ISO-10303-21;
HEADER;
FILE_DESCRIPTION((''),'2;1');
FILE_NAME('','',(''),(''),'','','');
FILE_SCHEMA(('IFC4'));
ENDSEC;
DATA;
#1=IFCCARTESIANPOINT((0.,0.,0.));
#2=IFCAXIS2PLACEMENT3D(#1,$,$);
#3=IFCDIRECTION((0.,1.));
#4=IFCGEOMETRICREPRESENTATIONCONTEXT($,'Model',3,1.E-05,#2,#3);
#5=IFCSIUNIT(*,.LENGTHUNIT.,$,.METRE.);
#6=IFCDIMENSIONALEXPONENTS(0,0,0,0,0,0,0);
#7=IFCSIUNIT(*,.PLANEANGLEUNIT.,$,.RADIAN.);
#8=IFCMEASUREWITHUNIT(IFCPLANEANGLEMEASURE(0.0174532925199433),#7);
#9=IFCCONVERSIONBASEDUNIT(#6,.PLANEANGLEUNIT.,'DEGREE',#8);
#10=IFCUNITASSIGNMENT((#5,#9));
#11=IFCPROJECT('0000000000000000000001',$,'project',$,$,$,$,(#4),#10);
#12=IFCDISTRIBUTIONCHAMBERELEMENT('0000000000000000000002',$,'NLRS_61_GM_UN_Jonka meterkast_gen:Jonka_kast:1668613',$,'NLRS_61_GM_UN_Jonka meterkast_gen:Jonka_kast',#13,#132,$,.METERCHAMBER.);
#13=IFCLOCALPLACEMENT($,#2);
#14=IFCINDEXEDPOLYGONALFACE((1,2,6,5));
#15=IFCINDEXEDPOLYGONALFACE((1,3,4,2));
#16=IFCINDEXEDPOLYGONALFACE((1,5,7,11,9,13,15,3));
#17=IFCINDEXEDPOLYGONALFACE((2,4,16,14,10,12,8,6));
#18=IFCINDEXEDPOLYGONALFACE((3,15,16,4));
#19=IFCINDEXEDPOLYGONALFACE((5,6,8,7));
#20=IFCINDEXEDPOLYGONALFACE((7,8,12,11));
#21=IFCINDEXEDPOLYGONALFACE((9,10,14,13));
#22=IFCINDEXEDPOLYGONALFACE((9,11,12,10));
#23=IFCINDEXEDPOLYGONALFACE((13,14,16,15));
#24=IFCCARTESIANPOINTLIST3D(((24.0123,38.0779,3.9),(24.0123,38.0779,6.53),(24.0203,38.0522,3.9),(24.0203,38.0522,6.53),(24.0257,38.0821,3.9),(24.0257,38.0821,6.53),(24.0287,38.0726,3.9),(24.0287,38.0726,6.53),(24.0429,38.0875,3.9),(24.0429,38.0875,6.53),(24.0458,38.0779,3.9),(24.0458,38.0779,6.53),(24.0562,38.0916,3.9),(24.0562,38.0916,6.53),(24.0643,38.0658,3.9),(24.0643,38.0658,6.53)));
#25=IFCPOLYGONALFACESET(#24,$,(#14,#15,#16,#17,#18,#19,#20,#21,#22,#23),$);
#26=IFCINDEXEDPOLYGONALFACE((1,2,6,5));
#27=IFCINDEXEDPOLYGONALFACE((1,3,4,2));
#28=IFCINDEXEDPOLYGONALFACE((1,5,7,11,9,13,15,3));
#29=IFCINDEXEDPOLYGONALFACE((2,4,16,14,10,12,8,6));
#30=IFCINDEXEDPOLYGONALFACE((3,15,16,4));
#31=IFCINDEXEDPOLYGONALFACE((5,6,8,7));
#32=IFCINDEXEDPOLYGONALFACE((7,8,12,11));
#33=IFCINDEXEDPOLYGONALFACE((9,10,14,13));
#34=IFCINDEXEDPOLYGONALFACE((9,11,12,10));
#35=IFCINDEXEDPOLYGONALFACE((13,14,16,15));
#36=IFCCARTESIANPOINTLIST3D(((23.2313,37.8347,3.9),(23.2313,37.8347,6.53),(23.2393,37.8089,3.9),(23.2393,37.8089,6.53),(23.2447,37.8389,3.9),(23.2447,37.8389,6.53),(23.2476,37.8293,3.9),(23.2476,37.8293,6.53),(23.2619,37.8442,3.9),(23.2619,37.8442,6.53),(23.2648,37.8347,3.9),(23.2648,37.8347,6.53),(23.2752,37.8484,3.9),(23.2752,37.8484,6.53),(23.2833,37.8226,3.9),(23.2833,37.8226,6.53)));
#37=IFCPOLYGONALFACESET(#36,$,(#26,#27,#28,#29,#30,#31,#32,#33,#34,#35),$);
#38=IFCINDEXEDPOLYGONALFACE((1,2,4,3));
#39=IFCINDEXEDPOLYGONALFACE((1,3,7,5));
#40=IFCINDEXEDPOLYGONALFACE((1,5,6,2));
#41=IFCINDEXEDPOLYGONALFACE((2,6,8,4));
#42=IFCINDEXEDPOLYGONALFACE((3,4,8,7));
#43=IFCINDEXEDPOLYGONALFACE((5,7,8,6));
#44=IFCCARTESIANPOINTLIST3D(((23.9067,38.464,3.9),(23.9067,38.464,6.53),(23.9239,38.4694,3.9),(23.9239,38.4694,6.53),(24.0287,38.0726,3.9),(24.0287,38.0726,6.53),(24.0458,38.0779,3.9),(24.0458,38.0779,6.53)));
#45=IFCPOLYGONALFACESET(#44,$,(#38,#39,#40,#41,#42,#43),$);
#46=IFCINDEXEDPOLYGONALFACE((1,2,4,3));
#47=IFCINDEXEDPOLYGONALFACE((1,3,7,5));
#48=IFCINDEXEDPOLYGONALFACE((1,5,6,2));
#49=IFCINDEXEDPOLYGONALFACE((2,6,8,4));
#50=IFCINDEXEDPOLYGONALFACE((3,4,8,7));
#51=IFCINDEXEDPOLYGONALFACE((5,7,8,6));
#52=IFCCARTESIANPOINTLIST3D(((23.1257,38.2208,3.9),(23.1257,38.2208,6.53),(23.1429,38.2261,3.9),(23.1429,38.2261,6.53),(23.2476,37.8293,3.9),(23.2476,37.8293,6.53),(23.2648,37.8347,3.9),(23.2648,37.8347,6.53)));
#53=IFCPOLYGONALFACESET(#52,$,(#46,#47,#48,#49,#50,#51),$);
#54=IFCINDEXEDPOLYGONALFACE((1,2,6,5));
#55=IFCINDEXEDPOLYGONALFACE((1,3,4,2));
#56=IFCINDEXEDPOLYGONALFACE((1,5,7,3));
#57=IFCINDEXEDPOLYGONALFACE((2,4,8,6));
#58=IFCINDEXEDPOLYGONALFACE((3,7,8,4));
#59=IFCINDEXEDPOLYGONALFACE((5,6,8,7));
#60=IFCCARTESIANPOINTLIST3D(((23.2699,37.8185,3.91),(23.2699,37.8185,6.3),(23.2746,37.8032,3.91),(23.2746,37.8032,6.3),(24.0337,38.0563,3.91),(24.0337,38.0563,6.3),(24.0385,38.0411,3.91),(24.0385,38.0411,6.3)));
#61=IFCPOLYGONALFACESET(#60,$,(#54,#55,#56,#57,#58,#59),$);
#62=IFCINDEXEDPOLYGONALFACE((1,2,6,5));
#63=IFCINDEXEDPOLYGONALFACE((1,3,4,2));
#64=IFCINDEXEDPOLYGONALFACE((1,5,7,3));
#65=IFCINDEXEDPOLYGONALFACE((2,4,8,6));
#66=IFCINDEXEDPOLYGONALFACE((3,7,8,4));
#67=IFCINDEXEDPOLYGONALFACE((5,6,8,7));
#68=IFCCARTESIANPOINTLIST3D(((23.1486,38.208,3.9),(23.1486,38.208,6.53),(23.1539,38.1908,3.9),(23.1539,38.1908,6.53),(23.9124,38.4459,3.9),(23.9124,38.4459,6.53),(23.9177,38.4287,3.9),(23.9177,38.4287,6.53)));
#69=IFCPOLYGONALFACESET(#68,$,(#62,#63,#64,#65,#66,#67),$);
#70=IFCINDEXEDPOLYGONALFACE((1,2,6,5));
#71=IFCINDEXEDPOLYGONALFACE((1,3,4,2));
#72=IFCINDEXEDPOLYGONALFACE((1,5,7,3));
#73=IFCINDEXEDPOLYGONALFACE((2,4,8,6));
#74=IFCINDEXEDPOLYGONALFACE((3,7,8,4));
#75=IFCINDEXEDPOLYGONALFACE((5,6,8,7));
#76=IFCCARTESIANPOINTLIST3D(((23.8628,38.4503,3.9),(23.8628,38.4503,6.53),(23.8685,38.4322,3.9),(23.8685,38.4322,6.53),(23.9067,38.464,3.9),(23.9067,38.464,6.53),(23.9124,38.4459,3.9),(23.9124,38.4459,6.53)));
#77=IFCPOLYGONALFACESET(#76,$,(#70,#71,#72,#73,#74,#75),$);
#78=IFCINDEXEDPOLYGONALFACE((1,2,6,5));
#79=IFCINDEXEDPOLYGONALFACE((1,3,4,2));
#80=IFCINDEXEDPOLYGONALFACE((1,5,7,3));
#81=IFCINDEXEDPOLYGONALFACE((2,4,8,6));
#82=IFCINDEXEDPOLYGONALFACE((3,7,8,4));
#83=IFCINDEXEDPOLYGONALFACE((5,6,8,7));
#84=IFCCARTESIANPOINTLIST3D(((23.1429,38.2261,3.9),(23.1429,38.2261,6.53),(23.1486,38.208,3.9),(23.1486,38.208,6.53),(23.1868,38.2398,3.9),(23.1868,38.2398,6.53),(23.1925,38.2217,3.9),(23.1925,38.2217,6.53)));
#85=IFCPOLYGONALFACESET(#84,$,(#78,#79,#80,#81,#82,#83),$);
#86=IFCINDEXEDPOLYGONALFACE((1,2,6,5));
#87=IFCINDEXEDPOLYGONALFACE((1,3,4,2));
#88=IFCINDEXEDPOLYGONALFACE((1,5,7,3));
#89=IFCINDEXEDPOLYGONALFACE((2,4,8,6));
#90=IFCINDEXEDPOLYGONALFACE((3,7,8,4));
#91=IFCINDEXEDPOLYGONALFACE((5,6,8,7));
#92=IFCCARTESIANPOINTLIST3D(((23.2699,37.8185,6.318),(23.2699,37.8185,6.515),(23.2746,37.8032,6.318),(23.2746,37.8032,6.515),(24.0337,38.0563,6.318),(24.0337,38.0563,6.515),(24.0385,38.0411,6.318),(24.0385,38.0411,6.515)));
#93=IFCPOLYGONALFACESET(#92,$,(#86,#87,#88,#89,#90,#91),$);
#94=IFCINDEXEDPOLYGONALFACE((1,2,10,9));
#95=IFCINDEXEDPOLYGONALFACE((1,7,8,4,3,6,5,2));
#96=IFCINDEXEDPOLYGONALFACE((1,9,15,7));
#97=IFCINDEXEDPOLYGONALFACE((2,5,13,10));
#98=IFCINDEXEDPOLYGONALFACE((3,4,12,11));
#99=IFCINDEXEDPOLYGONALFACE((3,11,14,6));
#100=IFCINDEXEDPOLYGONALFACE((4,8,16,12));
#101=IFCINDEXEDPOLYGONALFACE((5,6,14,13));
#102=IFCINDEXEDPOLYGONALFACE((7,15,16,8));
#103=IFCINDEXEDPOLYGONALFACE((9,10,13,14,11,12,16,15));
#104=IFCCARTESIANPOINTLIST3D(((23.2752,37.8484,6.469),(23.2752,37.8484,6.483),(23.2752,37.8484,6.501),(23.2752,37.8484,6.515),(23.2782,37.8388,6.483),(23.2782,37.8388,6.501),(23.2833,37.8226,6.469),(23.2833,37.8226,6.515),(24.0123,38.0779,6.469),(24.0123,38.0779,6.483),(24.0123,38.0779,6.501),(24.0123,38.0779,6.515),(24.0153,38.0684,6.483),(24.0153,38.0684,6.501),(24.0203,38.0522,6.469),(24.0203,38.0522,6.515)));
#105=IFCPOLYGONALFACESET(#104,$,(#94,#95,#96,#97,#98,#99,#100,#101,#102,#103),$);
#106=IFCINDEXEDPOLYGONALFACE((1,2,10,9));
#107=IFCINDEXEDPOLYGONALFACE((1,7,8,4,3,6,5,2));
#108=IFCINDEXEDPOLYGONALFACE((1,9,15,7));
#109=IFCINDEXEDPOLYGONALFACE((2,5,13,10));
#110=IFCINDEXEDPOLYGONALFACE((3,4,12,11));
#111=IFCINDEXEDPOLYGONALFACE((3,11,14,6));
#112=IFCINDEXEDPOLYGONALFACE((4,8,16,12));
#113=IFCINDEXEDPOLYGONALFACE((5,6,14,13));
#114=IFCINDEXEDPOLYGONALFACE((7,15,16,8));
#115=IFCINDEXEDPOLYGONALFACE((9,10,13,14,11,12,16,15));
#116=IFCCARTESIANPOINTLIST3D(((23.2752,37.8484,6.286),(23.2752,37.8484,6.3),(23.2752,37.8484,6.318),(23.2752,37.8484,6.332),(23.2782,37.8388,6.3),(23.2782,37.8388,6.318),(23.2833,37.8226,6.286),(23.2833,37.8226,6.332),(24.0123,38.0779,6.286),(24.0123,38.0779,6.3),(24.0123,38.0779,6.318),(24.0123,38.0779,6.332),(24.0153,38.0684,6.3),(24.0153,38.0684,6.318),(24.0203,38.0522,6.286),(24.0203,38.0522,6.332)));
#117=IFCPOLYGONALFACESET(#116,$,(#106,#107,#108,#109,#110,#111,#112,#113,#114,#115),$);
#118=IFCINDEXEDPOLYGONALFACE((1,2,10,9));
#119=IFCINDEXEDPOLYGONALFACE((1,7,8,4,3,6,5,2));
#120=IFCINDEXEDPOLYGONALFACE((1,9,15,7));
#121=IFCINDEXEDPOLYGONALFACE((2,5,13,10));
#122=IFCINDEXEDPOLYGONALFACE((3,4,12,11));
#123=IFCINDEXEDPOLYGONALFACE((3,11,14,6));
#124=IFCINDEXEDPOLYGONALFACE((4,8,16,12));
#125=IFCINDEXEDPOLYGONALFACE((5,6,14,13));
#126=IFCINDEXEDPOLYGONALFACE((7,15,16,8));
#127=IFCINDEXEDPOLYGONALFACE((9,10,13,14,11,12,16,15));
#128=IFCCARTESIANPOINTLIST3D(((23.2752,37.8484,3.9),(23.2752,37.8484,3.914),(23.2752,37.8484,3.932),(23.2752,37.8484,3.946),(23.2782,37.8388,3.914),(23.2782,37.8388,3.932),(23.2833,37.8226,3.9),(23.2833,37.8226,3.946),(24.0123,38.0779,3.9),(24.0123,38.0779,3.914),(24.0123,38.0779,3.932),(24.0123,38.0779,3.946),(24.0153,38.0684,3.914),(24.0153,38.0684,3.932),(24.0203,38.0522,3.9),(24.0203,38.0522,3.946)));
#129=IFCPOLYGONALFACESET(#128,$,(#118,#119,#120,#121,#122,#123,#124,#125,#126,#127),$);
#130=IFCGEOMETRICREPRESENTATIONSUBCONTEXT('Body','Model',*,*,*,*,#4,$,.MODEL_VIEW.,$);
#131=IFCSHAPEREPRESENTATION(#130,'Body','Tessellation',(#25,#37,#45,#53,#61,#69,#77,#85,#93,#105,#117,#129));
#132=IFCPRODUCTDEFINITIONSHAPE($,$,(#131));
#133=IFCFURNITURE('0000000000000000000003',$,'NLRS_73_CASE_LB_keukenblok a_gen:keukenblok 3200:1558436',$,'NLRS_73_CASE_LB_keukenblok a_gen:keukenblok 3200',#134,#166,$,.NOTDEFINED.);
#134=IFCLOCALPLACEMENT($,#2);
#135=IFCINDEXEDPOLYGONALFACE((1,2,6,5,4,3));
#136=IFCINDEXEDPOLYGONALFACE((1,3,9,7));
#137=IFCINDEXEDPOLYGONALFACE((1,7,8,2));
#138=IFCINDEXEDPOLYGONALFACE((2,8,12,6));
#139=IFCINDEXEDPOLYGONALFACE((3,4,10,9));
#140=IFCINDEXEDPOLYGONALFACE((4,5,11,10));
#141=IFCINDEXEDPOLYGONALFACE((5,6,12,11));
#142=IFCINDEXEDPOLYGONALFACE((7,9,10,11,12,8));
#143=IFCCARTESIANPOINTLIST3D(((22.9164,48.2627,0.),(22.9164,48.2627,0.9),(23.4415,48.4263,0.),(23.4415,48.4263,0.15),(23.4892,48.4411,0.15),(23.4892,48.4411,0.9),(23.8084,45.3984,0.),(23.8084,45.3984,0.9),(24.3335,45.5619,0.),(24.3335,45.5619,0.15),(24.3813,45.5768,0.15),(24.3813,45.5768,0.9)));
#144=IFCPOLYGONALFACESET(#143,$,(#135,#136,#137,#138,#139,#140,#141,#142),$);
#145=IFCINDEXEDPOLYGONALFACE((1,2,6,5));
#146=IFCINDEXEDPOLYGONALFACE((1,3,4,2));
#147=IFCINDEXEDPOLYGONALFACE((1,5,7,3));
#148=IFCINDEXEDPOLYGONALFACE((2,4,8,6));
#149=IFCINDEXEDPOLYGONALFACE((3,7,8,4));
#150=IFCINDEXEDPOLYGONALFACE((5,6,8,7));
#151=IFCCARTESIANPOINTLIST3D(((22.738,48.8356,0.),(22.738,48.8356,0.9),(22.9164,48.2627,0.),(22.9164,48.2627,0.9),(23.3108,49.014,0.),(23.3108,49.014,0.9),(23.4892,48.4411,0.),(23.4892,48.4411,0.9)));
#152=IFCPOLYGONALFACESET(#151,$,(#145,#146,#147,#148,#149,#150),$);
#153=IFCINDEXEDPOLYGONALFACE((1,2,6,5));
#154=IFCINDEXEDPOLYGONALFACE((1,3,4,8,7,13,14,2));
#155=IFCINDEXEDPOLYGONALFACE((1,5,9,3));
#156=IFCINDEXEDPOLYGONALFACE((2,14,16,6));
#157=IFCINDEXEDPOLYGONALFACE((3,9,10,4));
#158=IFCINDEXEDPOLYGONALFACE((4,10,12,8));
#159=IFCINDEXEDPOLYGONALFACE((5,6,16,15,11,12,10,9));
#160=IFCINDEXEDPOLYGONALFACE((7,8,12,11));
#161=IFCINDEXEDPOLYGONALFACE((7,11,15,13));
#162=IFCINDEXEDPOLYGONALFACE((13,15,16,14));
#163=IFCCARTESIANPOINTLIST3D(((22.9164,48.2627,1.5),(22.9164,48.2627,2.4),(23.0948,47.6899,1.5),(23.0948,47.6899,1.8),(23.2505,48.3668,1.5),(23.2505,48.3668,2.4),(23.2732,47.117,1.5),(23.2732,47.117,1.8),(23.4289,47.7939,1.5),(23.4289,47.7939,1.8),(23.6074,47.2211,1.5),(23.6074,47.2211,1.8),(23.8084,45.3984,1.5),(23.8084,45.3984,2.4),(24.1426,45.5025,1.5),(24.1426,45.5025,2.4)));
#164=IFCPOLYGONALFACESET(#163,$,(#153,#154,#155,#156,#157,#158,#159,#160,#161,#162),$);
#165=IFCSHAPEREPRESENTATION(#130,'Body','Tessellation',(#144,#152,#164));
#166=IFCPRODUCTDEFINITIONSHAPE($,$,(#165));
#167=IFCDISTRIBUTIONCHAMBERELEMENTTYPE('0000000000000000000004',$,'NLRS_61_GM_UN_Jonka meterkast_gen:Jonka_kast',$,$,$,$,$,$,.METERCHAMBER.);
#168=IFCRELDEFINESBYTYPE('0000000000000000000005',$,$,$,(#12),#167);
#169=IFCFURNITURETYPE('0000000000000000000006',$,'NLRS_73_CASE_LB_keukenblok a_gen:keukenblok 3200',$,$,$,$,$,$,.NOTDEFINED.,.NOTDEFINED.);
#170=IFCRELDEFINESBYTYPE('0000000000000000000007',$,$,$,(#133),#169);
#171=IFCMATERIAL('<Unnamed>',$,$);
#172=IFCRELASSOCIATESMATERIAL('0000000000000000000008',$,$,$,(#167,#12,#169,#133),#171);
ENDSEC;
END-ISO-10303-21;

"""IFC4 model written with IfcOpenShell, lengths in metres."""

from ifc_helpers import new_model, entity, si_unit, converted_unit, direction, frame, origin, place, context, subcontext, project, indexed_curve, outline, extrude, source, transform, mapped, material, type_object, element, save


model = new_model("IFC4")

# Units and contexts
model_context = context("Model", 3, precision=1e-05, world=origin(), true_north=direction((0.0, 1.0)))
body_context = subcontext(model_context, "Body", "Model", "MODEL_VIEW")
ifc_project = project(units=[si_unit("LENGTHUNIT", "METRE"), converted_unit("PLANEANGLEUNIT", "DEGREE", entity("IfcPlaneAngleMeasure", 0.0174532925199433), si_unit("PLANEANGLEUNIT", "RADIAN"), dimensions=[0, 0, 0, 0, 0, 0, 0])], contexts=[model_context])

# Shared definitions
ifc_material = material(Name="<Unnamed>")
distribution_chamber_element_type = type_object("IfcDistributionChamberElementType", Name="NLRS_61_GM_UN_Jonka meterkast_gen:Jonka_kast", PredefinedType="METERCHAMBER", material=ifc_material)
placement_1 = place(None, frame((13.1348, 11.9886, 0.0), z_axis=(0.0, 0.0, 1.0), x_axis=(0.954771, 0.297342, 0.0)))
placement_2 = place(placement_1, origin())
placement_3 = place(placement_2, origin())

# Distribution chamber element
shared_shape_1 = source(origin(), body_context, "Body", "SweptSolid", [
    extrude(outline(indexed_curve([(-0.023, -0.0093), (-0.009, -0.0093), (-0.009, 0.0007), (0.009, 0.0007), (0.009, -0.0093), (0.023, -0.0093), (0.023, 0.0178), (-0.023, 0.0178), (-0.023, -0.0093)], self_intersect=False)), frame((-0.409, 0.4092, 0.0)), (0.0, 0.0, 1.0), 2.63),
    extrude(outline(indexed_curve([(-0.023, -0.0093), (-0.009, -0.0093), (-0.009, 0.0007), (0.009, 0.0007), (0.009, -0.0093), (0.023, -0.0093), (0.023, 0.0178), (-0.023, 0.0178), (-0.023, -0.0093)], self_intersect=False)), frame((0.409, 0.4092, 0.0)), (0.0, 0.0, 1.0), 2.63),
    extrude(outline(indexed_curve([(-0.009, -0.205), (0.009, -0.205), (0.009, 0.205), (-0.009, 0.205), (-0.009, -0.205)], self_intersect=False)), frame((-0.409, 0.205, 0.0)), (0.0, 0.0, 1.0), 2.63),
    extrude(outline(indexed_curve([(-0.009, -0.205), (0.009, -0.205), (0.009, 0.205), (-0.009, 0.205), (-0.009, -0.205)], self_intersect=False)), frame((0.409, 0.205, 0.0)), (0.0, 0.0, 1.0), 2.63),
    extrude(outline(indexed_curve([(-0.008, -0.4), (0.008, -0.4), (0.008, 0.4), (-0.008, 0.4), (-0.008, -0.4)], self_intersect=False)), frame((0.0, 0.435, 0.01), z_axis=(0.0, 0.0, 1.0), x_axis=(0.0, 1.0, 0.0)), (0.0, 0.0, 1.0), 2.39),
    extrude(outline(indexed_curve([(-0.009, -0.4), (0.009, -0.4), (0.009, 0.4), (-0.009, 0.4), (-0.009, -0.4)], self_intersect=False)), frame((0.0, 0.028, 0.0), z_axis=(0.0, 0.0, 1.0), x_axis=(0.0, 1.0, 0.0)), (0.0, 0.0, 1.0), 2.63),
    extrude(outline(indexed_curve([(-0.0095, -0.023), (0.0095, -0.023), (0.0095, 0.023), (-0.0095, 0.023), (-0.0095, -0.023)], self_intersect=False)), frame((-0.377, 0.0095, 0.0), z_axis=(0.0, 0.0, 1.0), x_axis=(0.0, 1.0, 0.0)), (0.0, 0.0, 1.0), 2.63),
    extrude(outline(indexed_curve([(-0.0095, -0.023), (0.0095, -0.023), (0.0095, 0.023), (-0.0095, 0.023), (-0.0095, -0.023)], self_intersect=False)), frame((0.377, 0.0095, 0.0), z_axis=(0.0, 0.0, 1.0), x_axis=(0.0, 1.0, 0.0)), (0.0, 0.0, 1.0), 2.63),
    extrude(outline(indexed_curve([(-0.008, -0.4), (0.008, -0.4), (0.008, 0.4), (-0.008, 0.4), (-0.008, -0.4)], self_intersect=False)), frame((0.0, 0.435, 2.418), z_axis=(0.0, 0.0, 1.0), x_axis=(0.0, 1.0, 0.0)), (0.0, 0.0, 1.0), 0.197),
    extrude(outline(indexed_curve([(-0.0178, -0.023), (0.0093, -0.023), (0.0093, -0.009), (-0.0007, -0.009), (-0.0007, 0.009), (0.0093, 0.009), (0.0093, 0.023), (-0.0178, 0.023), (-0.0178, -0.023)], self_intersect=False)), frame((-0.386, 0.4092, 2.592), z_axis=(1.0, 0.0, 0.0), x_axis=(0.0, -1.0, 0.0)), (0.0, 0.0, 1.0), 0.772),
    extrude(outline(indexed_curve([(-0.0178, -0.023), (0.0093, -0.023), (0.0093, -0.009), (-0.0007, -0.009), (-0.0007, 0.009), (0.0093, 0.009), (0.0093, 0.023), (-0.0178, 0.023), (-0.0178, -0.023)], self_intersect=False)), frame((-0.386, 0.4092, 2.409), z_axis=(1.0, 0.0, 0.0), x_axis=(0.0, -1.0, 0.0)), (0.0, 0.0, 1.0), 0.772),
    extrude(outline(indexed_curve([(-0.0178, -0.023), (0.0093, -0.023), (0.0093, -0.009), (-0.0007, -0.009), (-0.0007, 0.009), (0.0093, 0.009), (0.0093, 0.023), (-0.0178, 0.023), (-0.0178, -0.023)], self_intersect=False)), frame((-0.386, 0.4092, 0.023), z_axis=(1.0, 0.0, 0.0), x_axis=(0.0, -1.0, 0.0)), (0.0, 0.0, 1.0), 0.772),
])
placement_4 = place(placement_2, frame((0.0, 0.0, 3.9)))
placement_5 = place(placement_4, origin())
distribution_chamber_element_1_placement = place(placement_5, frame((17.757, 22.075, 0.0), z_axis=(0.0, 0.0, 1.0), x_axis=(-1.0, 0.0, 0.0)))
element("IfcDistributionChamberElement", 1, at=distribution_chamber_element_1_placement, type_object=distribution_chamber_element_type, material=ifc_material, Name="NLRS_61_GM_UN_Jonka meterkast_gen:Jonka_kast:1668613", ObjectType="NLRS_61_GM_UN_Jonka meterkast_gen:Jonka_kast", PredefinedType="METERCHAMBER", context=body_context, shape_type="MappedRepresentation", body=[
    mapped(shared_shape_1, transform((0.0, 0.0, 0.0), scale=1.0)),
])

# Furniture
furniture_type = type_object("IfcFurnitureType", Name="NLRS_73_CASE_LB_keukenblok a_gen:keukenblok 3200", AssemblyPlace="NOTDEFINED", PredefinedType="NOTDEFINED", material=ifc_material)
shared_shape_2 = source(origin(), body_context, "Body", "SweptSolid", [
    extrude(outline(indexed_curve([(-0.1667, -0.35), (0.3833, -0.35), (0.3833, 0.55), (-0.2167, 0.55), (-0.2167, -0.2), (-0.1667, -0.2), (-0.1667, -0.35)], self_intersect=False)), frame((0.0, -0.3833, 0.35), z_axis=(1.0, 0.0, 0.0), x_axis=(0.0, 1.0, 0.0)), (0.0, 0.0, 1.0), 3.0),
    extrude(outline(indexed_curve([(-0.3, -0.3), (0.3, -0.3), (0.3, 0.3), (-0.3, 0.3), (-0.3, -0.3)], self_intersect=False)), frame((3.3, -0.3, 0.0), z_axis=(0.0, 0.0, 1.0), x_axis=(-1.0, 0.0, 0.0)), (0.0, 0.0, 1.0), 0.9),
    extrude(outline(indexed_curve([(-0.6, -1.2), (0.3, -1.2), (0.3, -0.6), (0.0, -0.6), (0.0, 0.0), (0.3, 0.0), (0.3, 1.8), (-0.6, 1.8), (-0.6, -1.2)], self_intersect=False)), frame((1.8, -0.35, 1.8), z_axis=(0.0, 1.0, 0.0), x_axis=(0.0, 0.0, -1.0)), (0.0, 0.0, 1.0), 0.35),
])
placement_6 = place(placement_3, origin())
furniture_placement = place(placement_6, frame((20.125, 28.725, 0.0), z_axis=(0.0, 0.0, 1.0), x_axis=(0.0, 1.0, 0.0)))
element("IfcFurniture", 2, at=furniture_placement, type_object=furniture_type, material=ifc_material, Name="NLRS_73_CASE_LB_keukenblok a_gen:keukenblok 3200:1558436", ObjectType="NLRS_73_CASE_LB_keukenblok a_gen:keukenblok 3200", PredefinedType="NOTDEFINED", context=body_context, shape_type="MappedRepresentation", body=[
    mapped(shared_shape_2, transform((0.0, 0.0, 0.0), scale=1.0)),
])

save(model, "model.ifc")
